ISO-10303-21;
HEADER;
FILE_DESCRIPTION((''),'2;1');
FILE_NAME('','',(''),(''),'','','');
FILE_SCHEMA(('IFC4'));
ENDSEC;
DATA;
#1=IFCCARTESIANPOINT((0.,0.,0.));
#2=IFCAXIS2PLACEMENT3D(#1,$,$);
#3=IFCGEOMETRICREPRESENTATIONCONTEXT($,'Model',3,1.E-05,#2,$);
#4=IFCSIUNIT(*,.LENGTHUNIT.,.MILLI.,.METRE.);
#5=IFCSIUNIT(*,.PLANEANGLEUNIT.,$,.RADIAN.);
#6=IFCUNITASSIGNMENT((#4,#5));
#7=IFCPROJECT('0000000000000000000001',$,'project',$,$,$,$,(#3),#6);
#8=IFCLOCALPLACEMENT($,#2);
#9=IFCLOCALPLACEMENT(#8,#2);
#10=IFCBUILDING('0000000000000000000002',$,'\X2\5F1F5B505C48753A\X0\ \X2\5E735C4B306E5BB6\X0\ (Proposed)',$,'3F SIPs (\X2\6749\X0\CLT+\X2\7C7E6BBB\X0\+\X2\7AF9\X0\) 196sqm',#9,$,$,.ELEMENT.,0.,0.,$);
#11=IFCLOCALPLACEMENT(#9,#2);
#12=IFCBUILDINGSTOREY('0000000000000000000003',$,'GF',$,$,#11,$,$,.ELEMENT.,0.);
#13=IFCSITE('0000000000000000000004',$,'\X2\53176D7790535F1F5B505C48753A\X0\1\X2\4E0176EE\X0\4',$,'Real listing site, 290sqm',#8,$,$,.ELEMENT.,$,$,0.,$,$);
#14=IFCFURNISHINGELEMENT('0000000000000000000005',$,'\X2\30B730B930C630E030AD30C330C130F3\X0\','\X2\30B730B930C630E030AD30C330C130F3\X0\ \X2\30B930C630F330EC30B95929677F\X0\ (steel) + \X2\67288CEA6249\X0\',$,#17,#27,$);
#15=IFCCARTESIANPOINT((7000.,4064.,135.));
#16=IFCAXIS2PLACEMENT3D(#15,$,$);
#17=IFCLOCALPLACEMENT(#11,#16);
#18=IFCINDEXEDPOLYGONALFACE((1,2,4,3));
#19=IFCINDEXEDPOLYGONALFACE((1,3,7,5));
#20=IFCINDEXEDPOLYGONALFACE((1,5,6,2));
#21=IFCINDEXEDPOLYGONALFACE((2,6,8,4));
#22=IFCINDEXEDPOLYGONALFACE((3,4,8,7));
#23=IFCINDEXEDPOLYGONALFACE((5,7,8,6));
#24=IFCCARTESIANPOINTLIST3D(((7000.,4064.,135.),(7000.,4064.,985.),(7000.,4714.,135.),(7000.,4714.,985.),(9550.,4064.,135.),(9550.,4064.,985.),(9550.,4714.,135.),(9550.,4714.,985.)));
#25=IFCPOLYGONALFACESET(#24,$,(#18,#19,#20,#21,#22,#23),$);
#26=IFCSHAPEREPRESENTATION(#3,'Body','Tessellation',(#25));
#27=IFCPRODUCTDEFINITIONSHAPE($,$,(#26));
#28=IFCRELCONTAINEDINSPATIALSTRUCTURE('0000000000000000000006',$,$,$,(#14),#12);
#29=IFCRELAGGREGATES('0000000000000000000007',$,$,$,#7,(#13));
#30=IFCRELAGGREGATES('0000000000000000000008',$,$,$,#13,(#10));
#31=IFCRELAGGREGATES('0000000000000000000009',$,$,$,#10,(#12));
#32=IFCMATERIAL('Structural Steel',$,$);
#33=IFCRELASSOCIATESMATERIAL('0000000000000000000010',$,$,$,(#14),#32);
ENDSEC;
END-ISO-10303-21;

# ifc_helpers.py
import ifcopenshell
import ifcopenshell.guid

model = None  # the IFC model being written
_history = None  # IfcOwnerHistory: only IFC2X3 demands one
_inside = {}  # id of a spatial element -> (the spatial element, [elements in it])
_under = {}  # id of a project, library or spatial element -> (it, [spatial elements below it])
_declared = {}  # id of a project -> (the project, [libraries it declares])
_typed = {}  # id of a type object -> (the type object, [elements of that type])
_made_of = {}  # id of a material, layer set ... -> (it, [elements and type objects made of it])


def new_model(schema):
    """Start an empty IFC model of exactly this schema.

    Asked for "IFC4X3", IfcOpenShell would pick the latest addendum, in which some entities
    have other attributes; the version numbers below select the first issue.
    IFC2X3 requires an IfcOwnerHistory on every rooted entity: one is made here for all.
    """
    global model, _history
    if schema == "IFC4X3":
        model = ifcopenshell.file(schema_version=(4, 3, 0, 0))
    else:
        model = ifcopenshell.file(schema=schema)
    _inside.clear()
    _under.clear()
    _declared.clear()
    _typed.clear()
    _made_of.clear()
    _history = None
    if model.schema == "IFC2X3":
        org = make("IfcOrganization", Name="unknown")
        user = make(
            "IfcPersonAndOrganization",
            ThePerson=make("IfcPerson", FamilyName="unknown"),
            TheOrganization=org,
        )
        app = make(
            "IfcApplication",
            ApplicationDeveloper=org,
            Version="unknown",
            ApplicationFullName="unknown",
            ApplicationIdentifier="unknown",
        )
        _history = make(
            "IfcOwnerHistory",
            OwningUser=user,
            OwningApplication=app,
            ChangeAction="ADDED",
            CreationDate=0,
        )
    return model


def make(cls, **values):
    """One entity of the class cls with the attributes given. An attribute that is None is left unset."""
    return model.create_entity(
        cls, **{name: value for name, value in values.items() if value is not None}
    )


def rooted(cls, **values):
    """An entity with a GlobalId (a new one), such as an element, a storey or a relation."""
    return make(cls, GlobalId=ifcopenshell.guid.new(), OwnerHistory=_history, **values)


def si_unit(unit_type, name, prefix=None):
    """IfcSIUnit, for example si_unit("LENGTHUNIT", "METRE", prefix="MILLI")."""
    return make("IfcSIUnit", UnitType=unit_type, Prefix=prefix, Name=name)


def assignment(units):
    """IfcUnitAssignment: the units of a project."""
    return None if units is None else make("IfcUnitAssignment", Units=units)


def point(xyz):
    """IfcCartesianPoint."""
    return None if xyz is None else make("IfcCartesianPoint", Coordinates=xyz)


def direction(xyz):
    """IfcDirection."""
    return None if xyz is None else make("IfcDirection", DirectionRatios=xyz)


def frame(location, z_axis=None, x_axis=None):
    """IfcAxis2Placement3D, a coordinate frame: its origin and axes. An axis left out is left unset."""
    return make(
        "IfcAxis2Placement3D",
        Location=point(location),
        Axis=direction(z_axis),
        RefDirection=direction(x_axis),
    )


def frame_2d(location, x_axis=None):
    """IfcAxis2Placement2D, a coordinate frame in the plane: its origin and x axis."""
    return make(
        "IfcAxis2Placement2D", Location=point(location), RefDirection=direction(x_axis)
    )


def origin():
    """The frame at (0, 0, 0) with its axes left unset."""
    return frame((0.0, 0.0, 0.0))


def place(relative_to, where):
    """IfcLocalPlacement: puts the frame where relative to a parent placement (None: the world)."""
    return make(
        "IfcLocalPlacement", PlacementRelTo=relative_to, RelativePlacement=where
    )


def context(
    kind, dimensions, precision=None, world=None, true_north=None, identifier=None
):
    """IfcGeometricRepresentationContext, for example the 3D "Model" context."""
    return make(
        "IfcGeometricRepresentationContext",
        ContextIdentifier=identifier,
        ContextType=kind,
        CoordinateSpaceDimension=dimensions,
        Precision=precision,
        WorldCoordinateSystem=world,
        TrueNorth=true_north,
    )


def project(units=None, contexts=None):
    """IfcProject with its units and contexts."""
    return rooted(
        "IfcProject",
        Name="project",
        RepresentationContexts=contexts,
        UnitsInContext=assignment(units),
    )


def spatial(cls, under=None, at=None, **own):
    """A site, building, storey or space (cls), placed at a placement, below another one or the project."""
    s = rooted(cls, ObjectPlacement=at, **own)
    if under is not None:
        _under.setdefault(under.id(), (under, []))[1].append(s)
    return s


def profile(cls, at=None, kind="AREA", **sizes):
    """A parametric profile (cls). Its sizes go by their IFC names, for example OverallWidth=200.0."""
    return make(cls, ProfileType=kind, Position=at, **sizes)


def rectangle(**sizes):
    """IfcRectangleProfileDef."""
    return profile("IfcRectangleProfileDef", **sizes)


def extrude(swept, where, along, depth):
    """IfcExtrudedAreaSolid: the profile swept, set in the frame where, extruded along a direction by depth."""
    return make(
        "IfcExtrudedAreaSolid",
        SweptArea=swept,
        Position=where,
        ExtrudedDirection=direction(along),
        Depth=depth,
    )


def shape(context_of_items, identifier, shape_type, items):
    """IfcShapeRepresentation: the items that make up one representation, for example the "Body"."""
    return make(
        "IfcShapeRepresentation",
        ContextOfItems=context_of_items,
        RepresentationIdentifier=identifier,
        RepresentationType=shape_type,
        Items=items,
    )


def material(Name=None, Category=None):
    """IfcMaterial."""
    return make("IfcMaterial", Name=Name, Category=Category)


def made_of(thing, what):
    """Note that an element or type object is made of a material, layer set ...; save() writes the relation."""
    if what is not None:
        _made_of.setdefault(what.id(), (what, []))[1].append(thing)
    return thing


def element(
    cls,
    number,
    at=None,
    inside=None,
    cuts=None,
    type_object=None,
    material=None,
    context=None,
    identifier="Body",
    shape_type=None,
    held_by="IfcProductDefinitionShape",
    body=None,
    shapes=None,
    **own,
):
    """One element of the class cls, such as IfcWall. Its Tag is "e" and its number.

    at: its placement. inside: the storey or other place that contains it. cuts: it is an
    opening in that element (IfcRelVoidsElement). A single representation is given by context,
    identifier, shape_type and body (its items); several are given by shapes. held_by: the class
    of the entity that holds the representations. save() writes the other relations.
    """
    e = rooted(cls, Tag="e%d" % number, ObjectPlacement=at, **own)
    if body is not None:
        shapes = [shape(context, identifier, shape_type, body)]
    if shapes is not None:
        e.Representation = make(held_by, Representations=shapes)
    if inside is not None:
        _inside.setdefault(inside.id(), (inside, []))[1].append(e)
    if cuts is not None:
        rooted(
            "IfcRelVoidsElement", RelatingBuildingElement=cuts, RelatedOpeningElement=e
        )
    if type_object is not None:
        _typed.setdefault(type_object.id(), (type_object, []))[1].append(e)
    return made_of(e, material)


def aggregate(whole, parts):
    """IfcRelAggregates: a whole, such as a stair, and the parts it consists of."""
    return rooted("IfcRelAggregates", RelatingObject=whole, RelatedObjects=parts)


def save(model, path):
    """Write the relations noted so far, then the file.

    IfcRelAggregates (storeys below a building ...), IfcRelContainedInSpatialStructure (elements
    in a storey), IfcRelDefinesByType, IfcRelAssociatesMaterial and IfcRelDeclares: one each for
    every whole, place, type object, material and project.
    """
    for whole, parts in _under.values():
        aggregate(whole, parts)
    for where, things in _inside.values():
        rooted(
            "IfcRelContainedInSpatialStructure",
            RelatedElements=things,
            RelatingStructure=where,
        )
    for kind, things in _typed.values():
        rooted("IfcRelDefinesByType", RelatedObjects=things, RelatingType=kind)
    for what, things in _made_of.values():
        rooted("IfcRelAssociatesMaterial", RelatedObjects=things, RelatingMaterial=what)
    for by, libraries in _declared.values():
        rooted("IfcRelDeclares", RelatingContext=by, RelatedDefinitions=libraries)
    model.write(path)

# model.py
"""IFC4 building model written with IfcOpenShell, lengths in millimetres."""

from ifc_helpers import new_model, si_unit, frame, frame_2d, origin, place, context, project, spatial, rectangle, extrude, material, element, save


model = new_model("IFC4")

# Units and contexts
model_context = context("Model", 3, precision=1e-05, world=origin())
ifc_project = project(units=[si_unit("LENGTHUNIT", "METRE", prefix="MILLI"), si_unit("PLANEANGLEUNIT", "RADIAN")], contexts=[model_context])

# Site, building, storey
site_placement = place(None, origin())
site = spatial("IfcSite", under=ifc_project, at=site_placement, Name="北海道弟子屈町1丁目4", ObjectType="Real listing site, 290sqm", CompositionType="ELEMENT", RefElevation=0.0)
building_placement = place(site_placement, origin())
building = spatial("IfcBuilding", under=site, at=building_placement, Name="弟子屈町 平屋の家 (Proposed)", ObjectType="3F SIPs (杉CLT+籾殻+竹) 196sqm", CompositionType="ELEMENT", ElevationOfRefHeight=0.0, ElevationOfTerrain=0.0)
storey_placement = place(building_placement, origin())
storey = spatial("IfcBuildingStorey", under=building, at=storey_placement, Name="GF", CompositionType="ELEMENT", Elevation=0.0)

# Furnishing element
ifc_material_1 = material(Name="Structural Steel")
furnishing_1_placement = place(storey_placement, frame((7000.0, 4064.0, 135.0)))
element("IfcFurnishingElement", 1, at=furnishing_1_placement, inside=storey, material=ifc_material_1, Name="システムキッチン", Description="システムキッチン ステンレス天板 (steel) + 木質扉", context=model_context, shape_type="SweptSolid", body=[
    extrude(rectangle(XDim=2550.0, YDim=650.0, at=frame_2d((1275.0, 325.0))), frame((7000.0, 4064.0, 135.0)), (0.0, 0.0, 1.0), 850.0),
])

save(model, "model.ifc")
